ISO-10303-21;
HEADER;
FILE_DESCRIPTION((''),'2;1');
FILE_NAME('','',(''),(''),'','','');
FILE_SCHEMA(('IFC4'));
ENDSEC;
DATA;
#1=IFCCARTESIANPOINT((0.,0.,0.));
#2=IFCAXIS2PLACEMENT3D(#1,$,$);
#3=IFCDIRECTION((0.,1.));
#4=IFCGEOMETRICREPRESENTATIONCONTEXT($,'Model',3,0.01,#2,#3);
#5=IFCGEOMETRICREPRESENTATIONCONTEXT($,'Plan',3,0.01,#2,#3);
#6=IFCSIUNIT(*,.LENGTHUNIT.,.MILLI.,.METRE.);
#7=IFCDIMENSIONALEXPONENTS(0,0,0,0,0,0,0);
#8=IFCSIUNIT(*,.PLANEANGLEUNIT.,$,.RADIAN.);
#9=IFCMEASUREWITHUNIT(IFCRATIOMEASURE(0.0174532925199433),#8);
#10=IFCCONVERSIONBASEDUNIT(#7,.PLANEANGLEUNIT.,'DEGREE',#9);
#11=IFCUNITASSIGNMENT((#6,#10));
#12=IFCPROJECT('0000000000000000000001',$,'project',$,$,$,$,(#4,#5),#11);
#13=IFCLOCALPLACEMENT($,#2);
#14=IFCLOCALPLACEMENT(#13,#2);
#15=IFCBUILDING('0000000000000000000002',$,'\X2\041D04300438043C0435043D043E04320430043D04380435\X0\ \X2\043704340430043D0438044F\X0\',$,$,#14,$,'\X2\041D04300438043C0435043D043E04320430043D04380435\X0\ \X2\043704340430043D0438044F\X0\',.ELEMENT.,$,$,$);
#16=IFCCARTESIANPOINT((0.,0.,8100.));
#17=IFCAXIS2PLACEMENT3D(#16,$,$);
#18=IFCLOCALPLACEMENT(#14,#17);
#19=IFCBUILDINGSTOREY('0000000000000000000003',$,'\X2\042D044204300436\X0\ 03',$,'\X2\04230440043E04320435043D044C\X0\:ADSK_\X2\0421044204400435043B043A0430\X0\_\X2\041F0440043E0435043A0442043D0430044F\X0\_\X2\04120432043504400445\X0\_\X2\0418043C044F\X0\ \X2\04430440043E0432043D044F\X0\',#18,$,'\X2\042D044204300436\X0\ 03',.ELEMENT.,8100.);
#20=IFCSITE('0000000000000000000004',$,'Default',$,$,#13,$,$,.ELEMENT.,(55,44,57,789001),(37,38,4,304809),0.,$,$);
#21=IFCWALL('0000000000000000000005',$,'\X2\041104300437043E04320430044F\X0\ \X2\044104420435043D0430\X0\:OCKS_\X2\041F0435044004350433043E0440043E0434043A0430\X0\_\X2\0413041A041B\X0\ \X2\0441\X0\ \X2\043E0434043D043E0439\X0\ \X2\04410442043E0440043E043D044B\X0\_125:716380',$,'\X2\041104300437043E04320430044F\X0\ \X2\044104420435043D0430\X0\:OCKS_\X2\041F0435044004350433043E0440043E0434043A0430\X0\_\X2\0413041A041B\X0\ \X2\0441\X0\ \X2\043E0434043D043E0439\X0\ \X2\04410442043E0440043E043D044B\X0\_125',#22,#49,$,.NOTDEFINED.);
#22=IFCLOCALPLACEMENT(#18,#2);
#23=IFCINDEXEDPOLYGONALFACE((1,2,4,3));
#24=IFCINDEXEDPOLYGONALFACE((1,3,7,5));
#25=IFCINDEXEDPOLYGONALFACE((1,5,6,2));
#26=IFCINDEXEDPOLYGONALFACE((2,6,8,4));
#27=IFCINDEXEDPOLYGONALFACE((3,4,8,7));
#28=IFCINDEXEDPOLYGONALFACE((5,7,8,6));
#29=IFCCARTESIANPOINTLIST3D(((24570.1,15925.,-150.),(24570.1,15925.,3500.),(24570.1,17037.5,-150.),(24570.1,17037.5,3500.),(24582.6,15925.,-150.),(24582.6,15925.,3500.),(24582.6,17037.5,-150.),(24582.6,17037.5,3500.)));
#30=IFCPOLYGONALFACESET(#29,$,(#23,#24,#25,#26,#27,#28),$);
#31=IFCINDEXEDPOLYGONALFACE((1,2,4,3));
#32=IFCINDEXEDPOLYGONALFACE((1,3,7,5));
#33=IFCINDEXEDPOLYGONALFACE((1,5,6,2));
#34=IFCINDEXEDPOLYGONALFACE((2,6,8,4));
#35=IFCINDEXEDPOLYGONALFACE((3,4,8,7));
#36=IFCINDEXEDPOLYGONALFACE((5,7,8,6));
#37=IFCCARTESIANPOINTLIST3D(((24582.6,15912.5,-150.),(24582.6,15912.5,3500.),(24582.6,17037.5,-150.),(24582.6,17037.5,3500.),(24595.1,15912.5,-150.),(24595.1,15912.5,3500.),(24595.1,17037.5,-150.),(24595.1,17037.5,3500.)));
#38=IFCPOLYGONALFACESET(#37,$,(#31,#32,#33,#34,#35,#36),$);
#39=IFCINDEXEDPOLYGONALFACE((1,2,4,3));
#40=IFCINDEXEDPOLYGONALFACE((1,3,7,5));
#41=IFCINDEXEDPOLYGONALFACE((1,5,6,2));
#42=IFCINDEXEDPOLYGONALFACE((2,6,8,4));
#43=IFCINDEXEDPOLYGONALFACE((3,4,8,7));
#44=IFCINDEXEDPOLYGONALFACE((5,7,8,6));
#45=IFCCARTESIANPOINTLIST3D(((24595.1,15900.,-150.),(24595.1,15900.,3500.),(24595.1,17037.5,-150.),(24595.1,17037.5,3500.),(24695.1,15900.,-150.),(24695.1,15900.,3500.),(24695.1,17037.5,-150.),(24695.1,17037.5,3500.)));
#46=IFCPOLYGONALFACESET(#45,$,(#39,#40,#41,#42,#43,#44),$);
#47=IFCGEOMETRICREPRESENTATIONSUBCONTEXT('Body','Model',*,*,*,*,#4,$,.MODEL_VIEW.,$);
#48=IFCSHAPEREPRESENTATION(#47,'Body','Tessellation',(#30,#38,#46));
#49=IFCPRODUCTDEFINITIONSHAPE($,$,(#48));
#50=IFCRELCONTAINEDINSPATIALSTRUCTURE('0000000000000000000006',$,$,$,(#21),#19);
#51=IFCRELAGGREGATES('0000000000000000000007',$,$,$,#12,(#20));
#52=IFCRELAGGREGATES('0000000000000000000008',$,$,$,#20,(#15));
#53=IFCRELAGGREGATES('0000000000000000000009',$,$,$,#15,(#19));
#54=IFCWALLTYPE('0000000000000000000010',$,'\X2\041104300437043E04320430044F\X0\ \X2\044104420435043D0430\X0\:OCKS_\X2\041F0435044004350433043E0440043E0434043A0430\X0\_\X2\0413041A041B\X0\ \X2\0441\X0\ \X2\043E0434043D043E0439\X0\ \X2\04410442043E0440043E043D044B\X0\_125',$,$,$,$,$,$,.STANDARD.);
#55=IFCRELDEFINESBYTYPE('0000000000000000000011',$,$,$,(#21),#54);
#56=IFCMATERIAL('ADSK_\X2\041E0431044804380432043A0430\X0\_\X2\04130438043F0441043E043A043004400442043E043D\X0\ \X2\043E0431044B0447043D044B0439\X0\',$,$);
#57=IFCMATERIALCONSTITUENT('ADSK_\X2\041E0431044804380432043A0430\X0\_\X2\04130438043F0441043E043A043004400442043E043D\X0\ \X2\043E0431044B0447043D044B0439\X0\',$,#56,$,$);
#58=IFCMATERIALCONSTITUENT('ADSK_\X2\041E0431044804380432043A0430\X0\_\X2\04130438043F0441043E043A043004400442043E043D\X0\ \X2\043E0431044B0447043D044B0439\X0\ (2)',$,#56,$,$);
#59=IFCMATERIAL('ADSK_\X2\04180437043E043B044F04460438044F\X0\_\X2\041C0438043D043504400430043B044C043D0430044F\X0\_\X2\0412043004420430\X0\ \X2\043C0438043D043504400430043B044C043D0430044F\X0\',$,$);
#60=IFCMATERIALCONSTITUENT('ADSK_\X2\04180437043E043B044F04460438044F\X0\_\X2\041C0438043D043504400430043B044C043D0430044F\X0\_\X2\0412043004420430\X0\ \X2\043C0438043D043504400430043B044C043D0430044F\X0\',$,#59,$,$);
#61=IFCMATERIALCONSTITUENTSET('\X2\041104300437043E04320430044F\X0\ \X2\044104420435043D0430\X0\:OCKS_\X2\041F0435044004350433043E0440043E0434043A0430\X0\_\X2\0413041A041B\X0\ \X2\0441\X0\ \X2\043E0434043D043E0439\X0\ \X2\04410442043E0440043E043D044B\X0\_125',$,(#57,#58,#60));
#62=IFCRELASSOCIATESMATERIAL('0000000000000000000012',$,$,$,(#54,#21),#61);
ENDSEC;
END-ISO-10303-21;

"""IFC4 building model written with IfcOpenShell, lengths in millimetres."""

from ifc_helpers import new_model, entity, si_unit, converted_unit, direction, frame, origin, place, context, subcontext, project, spatial, indexed_curve, outline, extrude, material, constituent, constituent_set, type_object, element, save


model = new_model("IFC4")

# Units and contexts
model_context = context("Model", 3, precision=0.01, world=origin(), true_north=direction((0.0, 1.0)))
plan_context = context("Plan", 3, precision=0.01, world=origin(), true_north=direction((0.0, 1.0)))
body_context = subcontext(model_context, "Body", "Model", "MODEL_VIEW")
ifc_project = project(units=[si_unit("LENGTHUNIT", "METRE", prefix="MILLI"), converted_unit("PLANEANGLEUNIT", "DEGREE", entity("IfcRatioMeasure", 0.0174532925199433), si_unit("PLANEANGLEUNIT", "RADIAN"), dimensions=[0, 0, 0, 0, 0, 0, 0])], contexts=[model_context, plan_context])

# Site, building, storey
site_placement = place(None, frame((0.0, 0.0, 0.0)))
site = spatial("IfcSite", under=ifc_project, at=site_placement, Name="Default", CompositionType="ELEMENT", RefLatitude=(55, 44, 57, 789001), RefLongitude=(37, 38, 4, 304809), RefElevation=0.0)
building_placement = place(site_placement, origin())
building = spatial("IfcBuilding", under=site, at=building_placement, Name="Наименование здания", LongName="Наименование здания", CompositionType="ELEMENT")
storey_placement = place(building_placement, frame((0.0, 0.0, 8100.0)))
storey = spatial("IfcBuildingStorey", under=building, at=storey_placement, Name="Этаж 03", ObjectType="Уровень:ADSK_Стрелка_Проектная_Вверх_Имя уровня", LongName="Этаж 03", CompositionType="ELEMENT", Elevation=8100.0)

# Shared definitions
ifc_material_1 = material(Name="ADSK_Обшивка_Гипсокартон обычный")
ifc_material_2 = material(Name="ADSK_Изоляция_Минеральная_Вата минеральная")

# Wall
ifc_constituent_1 = constituent(ifc_material_1, Name="ADSK_Обшивка_Гипсокартон обычный")
ifc_constituent_2 = constituent(ifc_material_1, Name="ADSK_Обшивка_Гипсокартон обычный (2)")
ifc_constituent_3 = constituent(ifc_material_2, Name="ADSK_Изоляция_Минеральная_Вата минеральная")
ifc_constituent_set_1 = constituent_set(constituents=[ifc_constituent_1, ifc_constituent_2, ifc_constituent_3], Name="Базовая стена:OCKS_Перегородка_ГКЛ с одной стороны_125")
wall_type_1 = type_object("IfcWallType", Name="Базовая стена:OCKS_Перегородка_ГКЛ с одной стороны_125", PredefinedType="STANDARD", material=ifc_constituent_set_1)
wall_1_placement = place(storey_placement, frame((24632.6, 17037.5, -150.0), z_axis=(0.0, 0.0, 1.0), x_axis=(0.0, -1.0, 0.0)))
element("IfcWall", 1, at=wall_1_placement, inside=storey, type_object=wall_type_1, material=ifc_constituent_set_1, Name="Базовая стена:OCKS_Перегородка_ГКЛ с одной стороны_125:716380", ObjectType="Базовая стена:OCKS_Перегородка_ГКЛ с одной стороны_125", PredefinedType="NOTDEFINED", context=body_context, shape_type="SweptSolid", body=[
    extrude(outline(indexed_curve([(-6.2, -556.2), (6.3, -556.2), (6.3, 556.2), (-6.2, 556.2), (-6.2, -556.2)], self_intersect=False)), frame((556.2, -56.3, 0.0), z_axis=(0.0, 0.0, 1.0), x_axis=(0.0, 1.0, 0.0)), (0.0, 0.0, 1.0), 3650.0),
    extrude(outline(indexed_curve([(-562.5, -6.3), (562.5, -6.3), (562.5, 6.2), (-562.5, 6.2), (-562.5, -6.3)], self_intersect=False)), frame((562.5, -43.7, 0.0)), (0.0, 0.0, 1.0), 3650.0),
    extrude(outline(indexed_curve([(-50.0, -568.7), (50.0, -568.7), (50.0, 568.7), (-50.0, 568.7), (-50.0, -568.7)], self_intersect=False)), frame((568.7, 12.5, 0.0), z_axis=(0.0, 0.0, 1.0), x_axis=(0.0, -1.0, 0.0)), (0.0, 0.0, 1.0), 3650.0),
])

save(model, "model.ifc")
